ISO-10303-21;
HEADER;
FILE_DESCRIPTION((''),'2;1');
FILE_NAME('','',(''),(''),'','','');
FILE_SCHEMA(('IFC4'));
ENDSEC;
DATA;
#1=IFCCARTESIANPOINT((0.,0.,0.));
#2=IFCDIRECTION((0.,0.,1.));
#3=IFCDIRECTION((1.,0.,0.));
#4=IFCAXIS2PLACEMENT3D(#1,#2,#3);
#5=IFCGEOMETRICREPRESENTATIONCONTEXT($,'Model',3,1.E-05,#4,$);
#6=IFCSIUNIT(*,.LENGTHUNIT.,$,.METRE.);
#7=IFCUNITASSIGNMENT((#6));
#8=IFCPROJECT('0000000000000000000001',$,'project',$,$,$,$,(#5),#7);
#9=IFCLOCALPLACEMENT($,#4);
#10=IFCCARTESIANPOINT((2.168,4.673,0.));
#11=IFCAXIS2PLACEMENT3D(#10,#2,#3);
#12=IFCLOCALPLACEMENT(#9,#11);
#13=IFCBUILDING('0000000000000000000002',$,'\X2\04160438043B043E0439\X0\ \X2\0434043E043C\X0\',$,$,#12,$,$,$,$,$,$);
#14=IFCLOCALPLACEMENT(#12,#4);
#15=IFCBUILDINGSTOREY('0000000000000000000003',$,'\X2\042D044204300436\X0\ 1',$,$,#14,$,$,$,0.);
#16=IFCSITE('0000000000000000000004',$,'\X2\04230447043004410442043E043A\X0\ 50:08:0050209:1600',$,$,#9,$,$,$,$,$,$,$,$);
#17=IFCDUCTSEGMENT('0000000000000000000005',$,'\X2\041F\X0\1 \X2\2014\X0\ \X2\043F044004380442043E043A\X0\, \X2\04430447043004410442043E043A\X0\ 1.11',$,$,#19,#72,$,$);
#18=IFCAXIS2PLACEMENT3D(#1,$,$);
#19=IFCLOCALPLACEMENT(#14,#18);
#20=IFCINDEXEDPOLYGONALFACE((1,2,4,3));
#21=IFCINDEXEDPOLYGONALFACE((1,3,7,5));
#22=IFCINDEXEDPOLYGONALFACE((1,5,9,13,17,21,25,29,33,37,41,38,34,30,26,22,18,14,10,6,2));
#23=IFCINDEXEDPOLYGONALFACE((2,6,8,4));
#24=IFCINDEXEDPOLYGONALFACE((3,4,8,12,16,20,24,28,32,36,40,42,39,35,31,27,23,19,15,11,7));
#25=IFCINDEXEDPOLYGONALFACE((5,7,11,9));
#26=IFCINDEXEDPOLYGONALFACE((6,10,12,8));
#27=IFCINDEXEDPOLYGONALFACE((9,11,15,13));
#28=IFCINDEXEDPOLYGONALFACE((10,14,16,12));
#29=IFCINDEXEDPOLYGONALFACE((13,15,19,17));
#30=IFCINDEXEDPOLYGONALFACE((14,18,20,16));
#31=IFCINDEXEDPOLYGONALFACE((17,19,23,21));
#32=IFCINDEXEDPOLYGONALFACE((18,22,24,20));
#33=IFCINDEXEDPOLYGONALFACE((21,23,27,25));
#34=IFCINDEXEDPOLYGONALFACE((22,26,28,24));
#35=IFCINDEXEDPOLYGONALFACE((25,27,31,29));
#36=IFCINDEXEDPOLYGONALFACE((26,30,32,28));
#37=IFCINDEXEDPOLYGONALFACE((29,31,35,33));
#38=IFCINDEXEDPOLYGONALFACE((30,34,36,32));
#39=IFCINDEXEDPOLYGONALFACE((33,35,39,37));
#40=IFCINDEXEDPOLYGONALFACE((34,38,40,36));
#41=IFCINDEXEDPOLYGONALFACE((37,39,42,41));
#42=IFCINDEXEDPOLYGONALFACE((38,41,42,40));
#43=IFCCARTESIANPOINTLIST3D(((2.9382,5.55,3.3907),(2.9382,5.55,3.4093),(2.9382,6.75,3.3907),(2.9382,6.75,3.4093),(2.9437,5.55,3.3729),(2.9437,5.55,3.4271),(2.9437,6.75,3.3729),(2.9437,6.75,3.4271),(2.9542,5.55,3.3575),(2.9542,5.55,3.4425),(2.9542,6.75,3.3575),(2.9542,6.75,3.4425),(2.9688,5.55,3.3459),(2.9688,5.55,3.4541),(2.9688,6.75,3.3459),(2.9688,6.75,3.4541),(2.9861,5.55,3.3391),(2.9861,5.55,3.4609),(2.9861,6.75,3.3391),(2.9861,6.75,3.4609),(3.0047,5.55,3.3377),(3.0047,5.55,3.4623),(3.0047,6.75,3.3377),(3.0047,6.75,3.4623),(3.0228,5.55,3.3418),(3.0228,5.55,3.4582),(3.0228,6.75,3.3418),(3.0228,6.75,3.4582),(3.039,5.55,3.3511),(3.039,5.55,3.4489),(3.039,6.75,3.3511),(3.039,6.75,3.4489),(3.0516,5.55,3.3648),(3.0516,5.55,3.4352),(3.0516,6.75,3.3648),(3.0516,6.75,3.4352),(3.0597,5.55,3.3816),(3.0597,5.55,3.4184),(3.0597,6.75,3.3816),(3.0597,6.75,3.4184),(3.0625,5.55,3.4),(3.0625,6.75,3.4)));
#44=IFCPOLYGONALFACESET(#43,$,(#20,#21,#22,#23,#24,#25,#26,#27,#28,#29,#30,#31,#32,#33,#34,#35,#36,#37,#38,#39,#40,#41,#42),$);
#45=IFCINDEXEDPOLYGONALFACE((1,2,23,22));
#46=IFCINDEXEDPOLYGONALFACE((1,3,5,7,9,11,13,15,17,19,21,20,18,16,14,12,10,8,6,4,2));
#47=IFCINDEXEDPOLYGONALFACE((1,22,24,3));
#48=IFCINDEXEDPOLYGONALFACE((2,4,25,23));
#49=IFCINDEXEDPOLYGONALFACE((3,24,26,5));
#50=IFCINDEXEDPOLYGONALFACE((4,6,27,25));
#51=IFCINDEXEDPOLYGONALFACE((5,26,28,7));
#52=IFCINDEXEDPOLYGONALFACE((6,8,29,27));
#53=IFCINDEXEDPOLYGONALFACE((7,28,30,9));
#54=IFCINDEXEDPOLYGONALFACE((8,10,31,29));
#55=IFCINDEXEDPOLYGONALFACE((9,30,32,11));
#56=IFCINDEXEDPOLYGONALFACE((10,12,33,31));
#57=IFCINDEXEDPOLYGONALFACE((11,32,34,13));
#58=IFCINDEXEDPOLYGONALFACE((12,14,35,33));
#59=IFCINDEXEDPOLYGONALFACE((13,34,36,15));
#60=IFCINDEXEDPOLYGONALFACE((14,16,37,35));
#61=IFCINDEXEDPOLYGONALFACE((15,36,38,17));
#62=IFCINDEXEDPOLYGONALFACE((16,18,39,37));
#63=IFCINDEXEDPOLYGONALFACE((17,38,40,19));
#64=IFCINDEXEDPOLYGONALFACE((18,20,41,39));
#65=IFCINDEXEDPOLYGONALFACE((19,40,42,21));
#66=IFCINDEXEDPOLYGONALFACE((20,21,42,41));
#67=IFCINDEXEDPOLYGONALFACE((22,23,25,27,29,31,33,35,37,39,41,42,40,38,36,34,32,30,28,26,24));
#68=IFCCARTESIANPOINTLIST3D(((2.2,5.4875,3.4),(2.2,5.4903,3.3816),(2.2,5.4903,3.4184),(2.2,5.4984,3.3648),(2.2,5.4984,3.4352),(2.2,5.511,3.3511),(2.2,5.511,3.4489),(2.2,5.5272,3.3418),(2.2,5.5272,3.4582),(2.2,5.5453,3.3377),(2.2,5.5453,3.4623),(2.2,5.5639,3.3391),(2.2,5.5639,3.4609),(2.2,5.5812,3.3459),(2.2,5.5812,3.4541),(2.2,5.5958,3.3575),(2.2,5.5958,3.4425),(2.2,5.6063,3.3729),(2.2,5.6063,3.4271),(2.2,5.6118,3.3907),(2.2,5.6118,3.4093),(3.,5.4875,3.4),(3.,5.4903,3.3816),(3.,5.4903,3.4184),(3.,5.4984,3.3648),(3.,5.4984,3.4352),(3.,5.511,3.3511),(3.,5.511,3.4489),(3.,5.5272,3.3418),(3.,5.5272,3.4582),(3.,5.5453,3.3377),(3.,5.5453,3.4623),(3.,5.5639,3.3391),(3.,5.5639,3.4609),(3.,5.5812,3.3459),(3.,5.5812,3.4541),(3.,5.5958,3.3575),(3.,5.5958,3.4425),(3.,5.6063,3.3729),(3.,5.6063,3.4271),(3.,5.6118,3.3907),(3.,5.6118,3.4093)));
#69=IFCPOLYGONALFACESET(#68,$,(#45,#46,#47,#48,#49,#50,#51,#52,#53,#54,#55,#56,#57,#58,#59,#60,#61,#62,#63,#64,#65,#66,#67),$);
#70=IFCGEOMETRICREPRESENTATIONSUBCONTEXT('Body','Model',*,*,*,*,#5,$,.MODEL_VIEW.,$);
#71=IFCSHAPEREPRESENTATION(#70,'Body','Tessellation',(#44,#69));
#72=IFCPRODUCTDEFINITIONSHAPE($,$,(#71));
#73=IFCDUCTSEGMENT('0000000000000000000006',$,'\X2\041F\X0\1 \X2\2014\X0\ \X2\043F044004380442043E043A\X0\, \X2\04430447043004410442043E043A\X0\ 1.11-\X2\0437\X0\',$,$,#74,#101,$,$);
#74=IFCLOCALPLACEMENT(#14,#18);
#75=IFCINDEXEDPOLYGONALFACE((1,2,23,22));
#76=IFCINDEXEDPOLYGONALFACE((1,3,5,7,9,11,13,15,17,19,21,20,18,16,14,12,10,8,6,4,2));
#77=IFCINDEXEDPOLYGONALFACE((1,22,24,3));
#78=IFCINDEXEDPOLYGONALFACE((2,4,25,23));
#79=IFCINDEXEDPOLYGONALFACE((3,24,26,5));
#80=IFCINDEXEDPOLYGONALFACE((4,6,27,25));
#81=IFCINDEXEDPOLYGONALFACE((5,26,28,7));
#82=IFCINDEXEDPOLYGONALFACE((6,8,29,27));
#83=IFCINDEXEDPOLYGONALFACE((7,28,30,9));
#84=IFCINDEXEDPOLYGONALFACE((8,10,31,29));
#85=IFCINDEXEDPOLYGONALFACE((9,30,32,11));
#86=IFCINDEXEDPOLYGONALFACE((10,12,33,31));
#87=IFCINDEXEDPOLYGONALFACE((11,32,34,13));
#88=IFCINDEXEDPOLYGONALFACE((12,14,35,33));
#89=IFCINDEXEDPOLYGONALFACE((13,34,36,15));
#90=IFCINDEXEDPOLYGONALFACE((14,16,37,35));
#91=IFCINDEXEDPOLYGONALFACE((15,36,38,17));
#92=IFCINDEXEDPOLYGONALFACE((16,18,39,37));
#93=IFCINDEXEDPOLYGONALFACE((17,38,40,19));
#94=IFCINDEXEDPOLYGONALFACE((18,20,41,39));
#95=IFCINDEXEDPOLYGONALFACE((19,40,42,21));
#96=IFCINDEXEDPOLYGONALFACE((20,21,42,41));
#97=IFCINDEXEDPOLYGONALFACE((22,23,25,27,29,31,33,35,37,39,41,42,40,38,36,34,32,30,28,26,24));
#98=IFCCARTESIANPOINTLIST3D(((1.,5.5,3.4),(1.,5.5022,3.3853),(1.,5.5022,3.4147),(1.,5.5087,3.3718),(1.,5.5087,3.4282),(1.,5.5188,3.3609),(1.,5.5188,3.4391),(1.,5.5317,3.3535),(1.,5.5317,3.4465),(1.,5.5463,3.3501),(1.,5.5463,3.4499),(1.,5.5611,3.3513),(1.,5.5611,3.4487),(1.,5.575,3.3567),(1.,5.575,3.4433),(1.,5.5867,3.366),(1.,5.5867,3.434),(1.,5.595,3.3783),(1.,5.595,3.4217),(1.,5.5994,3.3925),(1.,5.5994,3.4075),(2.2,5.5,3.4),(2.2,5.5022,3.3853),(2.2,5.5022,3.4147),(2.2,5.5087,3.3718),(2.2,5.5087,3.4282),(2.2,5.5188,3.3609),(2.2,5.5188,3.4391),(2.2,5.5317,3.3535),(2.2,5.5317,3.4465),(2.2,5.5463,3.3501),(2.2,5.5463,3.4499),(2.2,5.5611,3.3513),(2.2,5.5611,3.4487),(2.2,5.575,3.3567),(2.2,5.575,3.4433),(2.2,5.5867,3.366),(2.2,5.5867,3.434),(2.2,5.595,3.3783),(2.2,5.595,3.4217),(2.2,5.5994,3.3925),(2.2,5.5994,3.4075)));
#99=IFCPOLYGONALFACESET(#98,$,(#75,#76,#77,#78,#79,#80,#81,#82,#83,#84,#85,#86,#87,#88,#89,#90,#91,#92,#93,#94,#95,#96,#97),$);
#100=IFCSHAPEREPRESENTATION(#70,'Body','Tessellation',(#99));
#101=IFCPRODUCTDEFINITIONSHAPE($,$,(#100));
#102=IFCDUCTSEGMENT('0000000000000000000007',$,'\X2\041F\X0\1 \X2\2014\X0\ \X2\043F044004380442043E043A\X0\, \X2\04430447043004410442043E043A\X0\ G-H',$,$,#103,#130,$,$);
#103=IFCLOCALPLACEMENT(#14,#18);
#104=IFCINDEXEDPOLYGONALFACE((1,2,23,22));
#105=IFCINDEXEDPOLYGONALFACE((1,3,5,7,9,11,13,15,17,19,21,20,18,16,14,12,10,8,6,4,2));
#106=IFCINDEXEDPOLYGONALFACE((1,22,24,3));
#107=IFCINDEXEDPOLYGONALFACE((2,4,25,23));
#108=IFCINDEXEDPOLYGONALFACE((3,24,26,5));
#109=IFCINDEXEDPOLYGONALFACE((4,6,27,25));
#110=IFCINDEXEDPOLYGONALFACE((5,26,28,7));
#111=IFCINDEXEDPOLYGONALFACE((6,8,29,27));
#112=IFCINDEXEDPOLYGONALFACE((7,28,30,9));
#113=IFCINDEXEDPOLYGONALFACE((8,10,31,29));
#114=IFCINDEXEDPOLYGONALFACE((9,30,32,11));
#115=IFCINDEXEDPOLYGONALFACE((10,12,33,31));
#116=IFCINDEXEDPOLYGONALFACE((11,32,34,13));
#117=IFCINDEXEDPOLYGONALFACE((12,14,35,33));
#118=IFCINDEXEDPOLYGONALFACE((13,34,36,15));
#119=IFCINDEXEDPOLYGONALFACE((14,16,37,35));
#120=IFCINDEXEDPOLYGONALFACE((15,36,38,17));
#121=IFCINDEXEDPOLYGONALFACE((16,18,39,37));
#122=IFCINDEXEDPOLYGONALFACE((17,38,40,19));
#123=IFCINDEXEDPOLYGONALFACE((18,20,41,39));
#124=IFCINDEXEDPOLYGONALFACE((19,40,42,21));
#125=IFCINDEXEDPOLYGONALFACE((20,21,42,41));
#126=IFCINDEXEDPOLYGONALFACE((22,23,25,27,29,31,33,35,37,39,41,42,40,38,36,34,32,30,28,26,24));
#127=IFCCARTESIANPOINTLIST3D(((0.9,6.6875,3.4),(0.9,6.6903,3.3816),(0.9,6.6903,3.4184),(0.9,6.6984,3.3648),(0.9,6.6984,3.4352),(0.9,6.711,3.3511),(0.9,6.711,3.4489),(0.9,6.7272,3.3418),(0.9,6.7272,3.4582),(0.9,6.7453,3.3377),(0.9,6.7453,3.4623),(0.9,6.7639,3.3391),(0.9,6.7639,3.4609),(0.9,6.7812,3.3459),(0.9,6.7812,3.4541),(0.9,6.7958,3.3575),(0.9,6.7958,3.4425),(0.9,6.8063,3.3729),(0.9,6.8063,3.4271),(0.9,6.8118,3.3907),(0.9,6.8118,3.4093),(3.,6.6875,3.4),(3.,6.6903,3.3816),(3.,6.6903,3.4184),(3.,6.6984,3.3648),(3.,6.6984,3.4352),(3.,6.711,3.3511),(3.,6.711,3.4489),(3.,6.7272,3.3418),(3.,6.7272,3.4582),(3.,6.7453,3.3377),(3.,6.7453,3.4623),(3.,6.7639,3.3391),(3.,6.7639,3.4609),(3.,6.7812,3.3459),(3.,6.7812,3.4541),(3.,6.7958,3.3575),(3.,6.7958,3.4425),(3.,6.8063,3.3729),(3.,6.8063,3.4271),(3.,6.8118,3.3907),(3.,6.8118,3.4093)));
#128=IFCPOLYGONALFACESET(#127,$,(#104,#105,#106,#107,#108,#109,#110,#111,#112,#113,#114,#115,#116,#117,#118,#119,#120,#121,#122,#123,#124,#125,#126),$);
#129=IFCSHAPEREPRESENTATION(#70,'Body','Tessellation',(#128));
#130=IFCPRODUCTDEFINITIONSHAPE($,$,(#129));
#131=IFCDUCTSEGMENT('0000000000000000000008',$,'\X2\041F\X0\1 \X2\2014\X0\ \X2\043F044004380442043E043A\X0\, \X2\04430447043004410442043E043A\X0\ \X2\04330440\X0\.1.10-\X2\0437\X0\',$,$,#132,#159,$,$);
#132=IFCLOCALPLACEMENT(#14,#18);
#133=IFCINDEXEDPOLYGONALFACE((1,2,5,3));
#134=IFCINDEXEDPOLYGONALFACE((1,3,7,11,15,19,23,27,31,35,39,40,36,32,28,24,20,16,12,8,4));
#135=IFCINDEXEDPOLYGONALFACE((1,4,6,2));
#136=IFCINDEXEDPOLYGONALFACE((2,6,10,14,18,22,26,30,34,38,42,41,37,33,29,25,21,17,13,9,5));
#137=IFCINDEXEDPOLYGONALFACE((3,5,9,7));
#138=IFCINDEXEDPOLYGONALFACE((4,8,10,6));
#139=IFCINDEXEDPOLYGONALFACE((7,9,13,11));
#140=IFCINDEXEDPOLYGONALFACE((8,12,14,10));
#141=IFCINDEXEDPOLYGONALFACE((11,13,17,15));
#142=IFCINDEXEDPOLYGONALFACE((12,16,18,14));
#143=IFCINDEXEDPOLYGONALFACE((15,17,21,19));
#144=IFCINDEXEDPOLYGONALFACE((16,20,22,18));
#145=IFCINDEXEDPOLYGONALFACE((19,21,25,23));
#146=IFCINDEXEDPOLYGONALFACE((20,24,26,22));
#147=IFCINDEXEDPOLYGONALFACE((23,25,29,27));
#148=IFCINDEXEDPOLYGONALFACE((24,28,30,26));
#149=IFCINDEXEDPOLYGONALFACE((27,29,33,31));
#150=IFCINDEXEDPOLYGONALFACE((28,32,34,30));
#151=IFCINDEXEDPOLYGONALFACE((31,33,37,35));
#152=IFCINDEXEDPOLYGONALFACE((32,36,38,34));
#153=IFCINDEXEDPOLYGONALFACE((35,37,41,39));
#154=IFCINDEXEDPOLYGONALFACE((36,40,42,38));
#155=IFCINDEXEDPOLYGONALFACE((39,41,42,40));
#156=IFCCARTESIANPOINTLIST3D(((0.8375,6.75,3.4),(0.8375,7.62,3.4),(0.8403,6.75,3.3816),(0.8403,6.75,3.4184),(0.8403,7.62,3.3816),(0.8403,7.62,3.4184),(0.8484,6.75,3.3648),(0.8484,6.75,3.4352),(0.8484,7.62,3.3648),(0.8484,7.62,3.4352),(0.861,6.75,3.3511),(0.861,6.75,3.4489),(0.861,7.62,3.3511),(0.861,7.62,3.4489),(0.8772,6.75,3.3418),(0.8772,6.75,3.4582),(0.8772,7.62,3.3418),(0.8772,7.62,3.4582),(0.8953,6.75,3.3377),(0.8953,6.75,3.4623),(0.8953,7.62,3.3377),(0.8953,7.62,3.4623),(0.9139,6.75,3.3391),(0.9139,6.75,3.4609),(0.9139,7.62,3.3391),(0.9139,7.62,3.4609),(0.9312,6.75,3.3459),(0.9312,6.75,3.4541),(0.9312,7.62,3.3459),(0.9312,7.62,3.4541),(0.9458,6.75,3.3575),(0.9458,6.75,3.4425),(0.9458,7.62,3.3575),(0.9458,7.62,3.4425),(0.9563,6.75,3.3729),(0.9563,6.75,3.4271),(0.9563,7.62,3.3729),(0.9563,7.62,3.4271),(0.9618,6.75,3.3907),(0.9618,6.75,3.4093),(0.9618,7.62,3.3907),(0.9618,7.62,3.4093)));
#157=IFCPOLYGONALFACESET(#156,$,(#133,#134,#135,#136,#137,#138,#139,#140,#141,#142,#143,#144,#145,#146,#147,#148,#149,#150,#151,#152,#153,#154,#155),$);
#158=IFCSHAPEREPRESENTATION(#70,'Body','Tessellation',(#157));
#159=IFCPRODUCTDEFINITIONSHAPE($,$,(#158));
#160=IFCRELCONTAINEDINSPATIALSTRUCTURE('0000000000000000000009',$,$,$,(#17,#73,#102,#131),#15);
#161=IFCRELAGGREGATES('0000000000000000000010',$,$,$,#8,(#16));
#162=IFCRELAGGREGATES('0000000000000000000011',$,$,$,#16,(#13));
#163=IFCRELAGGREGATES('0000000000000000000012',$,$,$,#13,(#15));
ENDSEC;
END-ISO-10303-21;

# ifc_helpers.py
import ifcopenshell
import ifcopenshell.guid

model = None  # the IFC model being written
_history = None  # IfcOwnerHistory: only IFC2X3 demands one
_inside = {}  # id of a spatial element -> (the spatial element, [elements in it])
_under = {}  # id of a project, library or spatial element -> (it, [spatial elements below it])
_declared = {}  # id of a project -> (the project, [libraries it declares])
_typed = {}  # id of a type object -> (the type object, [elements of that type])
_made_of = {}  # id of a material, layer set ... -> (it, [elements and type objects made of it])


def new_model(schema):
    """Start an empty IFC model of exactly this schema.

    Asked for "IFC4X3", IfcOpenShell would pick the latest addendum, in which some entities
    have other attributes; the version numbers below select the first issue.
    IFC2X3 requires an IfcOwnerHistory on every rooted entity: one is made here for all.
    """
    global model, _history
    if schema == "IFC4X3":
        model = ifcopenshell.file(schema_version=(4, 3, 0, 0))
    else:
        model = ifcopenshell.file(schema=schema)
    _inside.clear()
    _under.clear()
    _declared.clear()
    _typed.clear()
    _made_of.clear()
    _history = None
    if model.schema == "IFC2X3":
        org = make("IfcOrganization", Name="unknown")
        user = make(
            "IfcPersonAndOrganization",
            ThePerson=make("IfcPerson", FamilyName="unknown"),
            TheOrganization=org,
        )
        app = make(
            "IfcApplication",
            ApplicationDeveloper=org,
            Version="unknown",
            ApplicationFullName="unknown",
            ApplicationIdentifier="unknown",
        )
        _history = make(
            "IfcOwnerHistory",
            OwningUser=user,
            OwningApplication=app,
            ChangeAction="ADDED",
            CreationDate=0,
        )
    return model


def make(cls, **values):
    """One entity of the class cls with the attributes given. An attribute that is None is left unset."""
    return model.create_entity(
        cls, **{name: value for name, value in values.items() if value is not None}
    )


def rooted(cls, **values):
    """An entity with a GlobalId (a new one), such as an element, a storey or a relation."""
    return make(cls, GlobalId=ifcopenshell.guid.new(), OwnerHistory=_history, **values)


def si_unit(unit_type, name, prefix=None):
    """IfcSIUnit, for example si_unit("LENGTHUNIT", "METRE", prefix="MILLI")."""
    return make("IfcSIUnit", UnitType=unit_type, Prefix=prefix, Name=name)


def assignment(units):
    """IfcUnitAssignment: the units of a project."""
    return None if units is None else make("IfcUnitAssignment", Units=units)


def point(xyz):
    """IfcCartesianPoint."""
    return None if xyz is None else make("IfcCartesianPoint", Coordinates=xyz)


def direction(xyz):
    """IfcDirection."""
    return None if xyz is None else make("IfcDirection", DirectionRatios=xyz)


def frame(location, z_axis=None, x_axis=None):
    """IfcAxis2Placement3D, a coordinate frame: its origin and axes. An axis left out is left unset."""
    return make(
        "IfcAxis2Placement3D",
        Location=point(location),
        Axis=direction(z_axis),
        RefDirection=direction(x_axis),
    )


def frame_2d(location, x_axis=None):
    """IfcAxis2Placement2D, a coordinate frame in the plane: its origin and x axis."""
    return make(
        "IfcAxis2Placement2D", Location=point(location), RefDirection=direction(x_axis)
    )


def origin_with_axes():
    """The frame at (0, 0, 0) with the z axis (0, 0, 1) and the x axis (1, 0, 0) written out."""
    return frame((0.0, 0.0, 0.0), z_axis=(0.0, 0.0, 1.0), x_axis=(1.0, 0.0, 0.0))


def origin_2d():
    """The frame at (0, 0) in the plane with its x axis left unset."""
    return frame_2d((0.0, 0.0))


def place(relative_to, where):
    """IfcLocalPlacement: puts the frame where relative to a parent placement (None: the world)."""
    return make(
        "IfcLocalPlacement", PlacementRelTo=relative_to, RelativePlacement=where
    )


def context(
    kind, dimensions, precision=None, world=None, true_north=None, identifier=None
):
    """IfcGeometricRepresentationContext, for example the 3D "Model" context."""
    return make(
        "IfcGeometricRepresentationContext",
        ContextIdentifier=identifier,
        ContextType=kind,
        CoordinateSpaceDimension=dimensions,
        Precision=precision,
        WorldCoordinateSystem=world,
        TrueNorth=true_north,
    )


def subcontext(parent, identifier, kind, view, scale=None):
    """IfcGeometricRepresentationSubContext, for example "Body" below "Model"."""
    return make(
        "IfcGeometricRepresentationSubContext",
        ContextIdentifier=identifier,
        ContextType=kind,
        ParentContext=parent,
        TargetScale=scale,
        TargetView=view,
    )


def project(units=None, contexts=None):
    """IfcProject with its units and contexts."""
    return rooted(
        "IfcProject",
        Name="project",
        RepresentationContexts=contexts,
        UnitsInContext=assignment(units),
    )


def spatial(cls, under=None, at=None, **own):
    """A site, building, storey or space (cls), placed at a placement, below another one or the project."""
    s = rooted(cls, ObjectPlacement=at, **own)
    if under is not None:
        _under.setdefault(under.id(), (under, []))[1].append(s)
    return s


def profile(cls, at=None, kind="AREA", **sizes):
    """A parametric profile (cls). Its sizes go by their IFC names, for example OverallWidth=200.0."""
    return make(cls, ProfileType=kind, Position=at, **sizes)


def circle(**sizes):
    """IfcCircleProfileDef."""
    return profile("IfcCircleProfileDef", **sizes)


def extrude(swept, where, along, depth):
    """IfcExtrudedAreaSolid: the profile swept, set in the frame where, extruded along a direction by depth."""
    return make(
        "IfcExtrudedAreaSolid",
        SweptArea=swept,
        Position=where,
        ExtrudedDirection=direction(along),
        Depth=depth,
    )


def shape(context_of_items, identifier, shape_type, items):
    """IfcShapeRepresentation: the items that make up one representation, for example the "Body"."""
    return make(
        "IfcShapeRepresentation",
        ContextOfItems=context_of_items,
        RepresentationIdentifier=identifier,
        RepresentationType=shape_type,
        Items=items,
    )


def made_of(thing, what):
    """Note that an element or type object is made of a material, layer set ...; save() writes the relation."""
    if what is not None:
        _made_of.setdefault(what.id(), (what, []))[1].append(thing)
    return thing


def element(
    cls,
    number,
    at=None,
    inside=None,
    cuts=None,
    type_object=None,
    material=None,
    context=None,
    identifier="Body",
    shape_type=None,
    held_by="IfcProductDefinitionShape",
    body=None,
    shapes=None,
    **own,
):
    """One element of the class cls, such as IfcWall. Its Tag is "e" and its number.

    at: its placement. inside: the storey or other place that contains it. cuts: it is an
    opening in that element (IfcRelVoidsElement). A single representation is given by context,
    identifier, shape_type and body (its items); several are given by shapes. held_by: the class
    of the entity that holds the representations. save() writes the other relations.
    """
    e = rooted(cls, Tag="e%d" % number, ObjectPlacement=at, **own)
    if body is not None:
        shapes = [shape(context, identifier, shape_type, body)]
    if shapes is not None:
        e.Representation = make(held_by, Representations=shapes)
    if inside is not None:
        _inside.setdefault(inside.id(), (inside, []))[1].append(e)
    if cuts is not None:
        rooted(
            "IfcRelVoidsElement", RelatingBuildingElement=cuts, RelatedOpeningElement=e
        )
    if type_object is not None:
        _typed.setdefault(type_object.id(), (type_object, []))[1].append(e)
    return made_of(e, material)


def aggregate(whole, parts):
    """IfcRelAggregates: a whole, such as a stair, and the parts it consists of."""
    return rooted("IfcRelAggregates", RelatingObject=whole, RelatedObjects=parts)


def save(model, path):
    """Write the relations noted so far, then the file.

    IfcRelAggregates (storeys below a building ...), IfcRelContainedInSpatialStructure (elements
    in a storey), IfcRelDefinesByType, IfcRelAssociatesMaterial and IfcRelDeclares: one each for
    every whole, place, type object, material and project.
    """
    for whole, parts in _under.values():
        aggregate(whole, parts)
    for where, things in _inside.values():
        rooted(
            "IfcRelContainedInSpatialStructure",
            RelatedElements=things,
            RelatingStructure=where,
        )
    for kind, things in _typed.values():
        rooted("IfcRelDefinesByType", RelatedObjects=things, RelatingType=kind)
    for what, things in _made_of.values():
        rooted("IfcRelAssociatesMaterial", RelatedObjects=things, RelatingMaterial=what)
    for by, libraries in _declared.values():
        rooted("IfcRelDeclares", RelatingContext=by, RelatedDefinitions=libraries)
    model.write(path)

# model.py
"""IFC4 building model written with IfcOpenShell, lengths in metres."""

from ifc_helpers import new_model, si_unit, frame, origin_with_axes, origin_2d, place, context, subcontext, project, spatial, circle, extrude, element, save


model = new_model("IFC4")

# Units and contexts
model_context = context("Model", 3, precision=1e-05, world=origin_with_axes())
body_context = subcontext(model_context, "Body", "Model", "MODEL_VIEW")
ifc_project = project(units=[si_unit("LENGTHUNIT", "METRE")], contexts=[model_context])

# Site, building, storey
site_placement = place(None, origin_with_axes())
site = spatial("IfcSite", under=ifc_project, at=site_placement, Name="Участок 50:08:0050209:1600")
building_placement = place(site_placement, frame((2.168, 4.673, 0.0), z_axis=(0.0, 0.0, 1.0), x_axis=(1.0, 0.0, 0.0)))
building = spatial("IfcBuilding", under=site, at=building_placement, Name="Жилой дом")
storey_placement = place(building_placement, origin_with_axes())
storey = spatial("IfcBuildingStorey", under=building, at=storey_placement, Name="Этаж 1", Elevation=0.0)

# Duct segments
duct_segment_1_placement = place(storey_placement, origin_with_axes())
element("IfcDuctSegment", 1, at=duct_segment_1_placement, inside=storey, Name="П1 — приток, участок 1.11", context=body_context, shape_type="SweptSolid", body=[
    extrude(circle(Radius=0.0625, at=origin_2d()), frame((3.0, 6.75, 3.4), z_axis=(0.0, -1.0, 0.0), x_axis=(1.0, 0.0, 0.0)), (0.0, 0.0, 1.0), 1.2),
    extrude(circle(Radius=0.0625, at=origin_2d()), frame((3.0, 5.55, 3.4), z_axis=(-1.0, 0.0, 0.0), x_axis=(0.0, -1.0, 0.0)), (0.0, 0.0, 1.0), 0.8),
])
duct_segment_2_placement = place(storey_placement, origin_with_axes())
element("IfcDuctSegment", 2, at=duct_segment_2_placement, inside=storey, Name="П1 — приток, участок 1.11-з", context=body_context, shape_type="SweptSolid", body=[
    extrude(circle(Radius=0.05, at=origin_2d()), frame((2.2, 5.55, 3.4), z_axis=(-1.0, 0.0, 0.0), x_axis=(0.0, -1.0, 0.0)), (0.0, 0.0, 1.0), 1.2),
])
duct_segment_3_placement = place(storey_placement, origin_with_axes())
element("IfcDuctSegment", 3, at=duct_segment_3_placement, inside=storey, Name="П1 — приток, участок G-H", context=body_context, shape_type="SweptSolid", body=[
    extrude(circle(Radius=0.0625, at=origin_2d()), frame((3.0, 6.75, 3.4), z_axis=(-1.0, 0.0, 0.0), x_axis=(0.0, -1.0, 0.0)), (0.0, 0.0, 1.0), 2.1),
])
duct_segment_4_placement = place(storey_placement, origin_with_axes())
element("IfcDuctSegment", 4, at=duct_segment_4_placement, inside=storey, Name="П1 — приток, участок гр.1.10-з", context=body_context, shape_type="SweptSolid", body=[
    extrude(circle(Radius=0.0625, at=origin_2d()), frame((0.9, 6.75, 3.4), z_axis=(0.0, 1.0, 0.0), x_axis=(-1.0, 0.0, 0.0)), (0.0, 0.0, 1.0), 0.87),
])

save(model, "model.ifc")
